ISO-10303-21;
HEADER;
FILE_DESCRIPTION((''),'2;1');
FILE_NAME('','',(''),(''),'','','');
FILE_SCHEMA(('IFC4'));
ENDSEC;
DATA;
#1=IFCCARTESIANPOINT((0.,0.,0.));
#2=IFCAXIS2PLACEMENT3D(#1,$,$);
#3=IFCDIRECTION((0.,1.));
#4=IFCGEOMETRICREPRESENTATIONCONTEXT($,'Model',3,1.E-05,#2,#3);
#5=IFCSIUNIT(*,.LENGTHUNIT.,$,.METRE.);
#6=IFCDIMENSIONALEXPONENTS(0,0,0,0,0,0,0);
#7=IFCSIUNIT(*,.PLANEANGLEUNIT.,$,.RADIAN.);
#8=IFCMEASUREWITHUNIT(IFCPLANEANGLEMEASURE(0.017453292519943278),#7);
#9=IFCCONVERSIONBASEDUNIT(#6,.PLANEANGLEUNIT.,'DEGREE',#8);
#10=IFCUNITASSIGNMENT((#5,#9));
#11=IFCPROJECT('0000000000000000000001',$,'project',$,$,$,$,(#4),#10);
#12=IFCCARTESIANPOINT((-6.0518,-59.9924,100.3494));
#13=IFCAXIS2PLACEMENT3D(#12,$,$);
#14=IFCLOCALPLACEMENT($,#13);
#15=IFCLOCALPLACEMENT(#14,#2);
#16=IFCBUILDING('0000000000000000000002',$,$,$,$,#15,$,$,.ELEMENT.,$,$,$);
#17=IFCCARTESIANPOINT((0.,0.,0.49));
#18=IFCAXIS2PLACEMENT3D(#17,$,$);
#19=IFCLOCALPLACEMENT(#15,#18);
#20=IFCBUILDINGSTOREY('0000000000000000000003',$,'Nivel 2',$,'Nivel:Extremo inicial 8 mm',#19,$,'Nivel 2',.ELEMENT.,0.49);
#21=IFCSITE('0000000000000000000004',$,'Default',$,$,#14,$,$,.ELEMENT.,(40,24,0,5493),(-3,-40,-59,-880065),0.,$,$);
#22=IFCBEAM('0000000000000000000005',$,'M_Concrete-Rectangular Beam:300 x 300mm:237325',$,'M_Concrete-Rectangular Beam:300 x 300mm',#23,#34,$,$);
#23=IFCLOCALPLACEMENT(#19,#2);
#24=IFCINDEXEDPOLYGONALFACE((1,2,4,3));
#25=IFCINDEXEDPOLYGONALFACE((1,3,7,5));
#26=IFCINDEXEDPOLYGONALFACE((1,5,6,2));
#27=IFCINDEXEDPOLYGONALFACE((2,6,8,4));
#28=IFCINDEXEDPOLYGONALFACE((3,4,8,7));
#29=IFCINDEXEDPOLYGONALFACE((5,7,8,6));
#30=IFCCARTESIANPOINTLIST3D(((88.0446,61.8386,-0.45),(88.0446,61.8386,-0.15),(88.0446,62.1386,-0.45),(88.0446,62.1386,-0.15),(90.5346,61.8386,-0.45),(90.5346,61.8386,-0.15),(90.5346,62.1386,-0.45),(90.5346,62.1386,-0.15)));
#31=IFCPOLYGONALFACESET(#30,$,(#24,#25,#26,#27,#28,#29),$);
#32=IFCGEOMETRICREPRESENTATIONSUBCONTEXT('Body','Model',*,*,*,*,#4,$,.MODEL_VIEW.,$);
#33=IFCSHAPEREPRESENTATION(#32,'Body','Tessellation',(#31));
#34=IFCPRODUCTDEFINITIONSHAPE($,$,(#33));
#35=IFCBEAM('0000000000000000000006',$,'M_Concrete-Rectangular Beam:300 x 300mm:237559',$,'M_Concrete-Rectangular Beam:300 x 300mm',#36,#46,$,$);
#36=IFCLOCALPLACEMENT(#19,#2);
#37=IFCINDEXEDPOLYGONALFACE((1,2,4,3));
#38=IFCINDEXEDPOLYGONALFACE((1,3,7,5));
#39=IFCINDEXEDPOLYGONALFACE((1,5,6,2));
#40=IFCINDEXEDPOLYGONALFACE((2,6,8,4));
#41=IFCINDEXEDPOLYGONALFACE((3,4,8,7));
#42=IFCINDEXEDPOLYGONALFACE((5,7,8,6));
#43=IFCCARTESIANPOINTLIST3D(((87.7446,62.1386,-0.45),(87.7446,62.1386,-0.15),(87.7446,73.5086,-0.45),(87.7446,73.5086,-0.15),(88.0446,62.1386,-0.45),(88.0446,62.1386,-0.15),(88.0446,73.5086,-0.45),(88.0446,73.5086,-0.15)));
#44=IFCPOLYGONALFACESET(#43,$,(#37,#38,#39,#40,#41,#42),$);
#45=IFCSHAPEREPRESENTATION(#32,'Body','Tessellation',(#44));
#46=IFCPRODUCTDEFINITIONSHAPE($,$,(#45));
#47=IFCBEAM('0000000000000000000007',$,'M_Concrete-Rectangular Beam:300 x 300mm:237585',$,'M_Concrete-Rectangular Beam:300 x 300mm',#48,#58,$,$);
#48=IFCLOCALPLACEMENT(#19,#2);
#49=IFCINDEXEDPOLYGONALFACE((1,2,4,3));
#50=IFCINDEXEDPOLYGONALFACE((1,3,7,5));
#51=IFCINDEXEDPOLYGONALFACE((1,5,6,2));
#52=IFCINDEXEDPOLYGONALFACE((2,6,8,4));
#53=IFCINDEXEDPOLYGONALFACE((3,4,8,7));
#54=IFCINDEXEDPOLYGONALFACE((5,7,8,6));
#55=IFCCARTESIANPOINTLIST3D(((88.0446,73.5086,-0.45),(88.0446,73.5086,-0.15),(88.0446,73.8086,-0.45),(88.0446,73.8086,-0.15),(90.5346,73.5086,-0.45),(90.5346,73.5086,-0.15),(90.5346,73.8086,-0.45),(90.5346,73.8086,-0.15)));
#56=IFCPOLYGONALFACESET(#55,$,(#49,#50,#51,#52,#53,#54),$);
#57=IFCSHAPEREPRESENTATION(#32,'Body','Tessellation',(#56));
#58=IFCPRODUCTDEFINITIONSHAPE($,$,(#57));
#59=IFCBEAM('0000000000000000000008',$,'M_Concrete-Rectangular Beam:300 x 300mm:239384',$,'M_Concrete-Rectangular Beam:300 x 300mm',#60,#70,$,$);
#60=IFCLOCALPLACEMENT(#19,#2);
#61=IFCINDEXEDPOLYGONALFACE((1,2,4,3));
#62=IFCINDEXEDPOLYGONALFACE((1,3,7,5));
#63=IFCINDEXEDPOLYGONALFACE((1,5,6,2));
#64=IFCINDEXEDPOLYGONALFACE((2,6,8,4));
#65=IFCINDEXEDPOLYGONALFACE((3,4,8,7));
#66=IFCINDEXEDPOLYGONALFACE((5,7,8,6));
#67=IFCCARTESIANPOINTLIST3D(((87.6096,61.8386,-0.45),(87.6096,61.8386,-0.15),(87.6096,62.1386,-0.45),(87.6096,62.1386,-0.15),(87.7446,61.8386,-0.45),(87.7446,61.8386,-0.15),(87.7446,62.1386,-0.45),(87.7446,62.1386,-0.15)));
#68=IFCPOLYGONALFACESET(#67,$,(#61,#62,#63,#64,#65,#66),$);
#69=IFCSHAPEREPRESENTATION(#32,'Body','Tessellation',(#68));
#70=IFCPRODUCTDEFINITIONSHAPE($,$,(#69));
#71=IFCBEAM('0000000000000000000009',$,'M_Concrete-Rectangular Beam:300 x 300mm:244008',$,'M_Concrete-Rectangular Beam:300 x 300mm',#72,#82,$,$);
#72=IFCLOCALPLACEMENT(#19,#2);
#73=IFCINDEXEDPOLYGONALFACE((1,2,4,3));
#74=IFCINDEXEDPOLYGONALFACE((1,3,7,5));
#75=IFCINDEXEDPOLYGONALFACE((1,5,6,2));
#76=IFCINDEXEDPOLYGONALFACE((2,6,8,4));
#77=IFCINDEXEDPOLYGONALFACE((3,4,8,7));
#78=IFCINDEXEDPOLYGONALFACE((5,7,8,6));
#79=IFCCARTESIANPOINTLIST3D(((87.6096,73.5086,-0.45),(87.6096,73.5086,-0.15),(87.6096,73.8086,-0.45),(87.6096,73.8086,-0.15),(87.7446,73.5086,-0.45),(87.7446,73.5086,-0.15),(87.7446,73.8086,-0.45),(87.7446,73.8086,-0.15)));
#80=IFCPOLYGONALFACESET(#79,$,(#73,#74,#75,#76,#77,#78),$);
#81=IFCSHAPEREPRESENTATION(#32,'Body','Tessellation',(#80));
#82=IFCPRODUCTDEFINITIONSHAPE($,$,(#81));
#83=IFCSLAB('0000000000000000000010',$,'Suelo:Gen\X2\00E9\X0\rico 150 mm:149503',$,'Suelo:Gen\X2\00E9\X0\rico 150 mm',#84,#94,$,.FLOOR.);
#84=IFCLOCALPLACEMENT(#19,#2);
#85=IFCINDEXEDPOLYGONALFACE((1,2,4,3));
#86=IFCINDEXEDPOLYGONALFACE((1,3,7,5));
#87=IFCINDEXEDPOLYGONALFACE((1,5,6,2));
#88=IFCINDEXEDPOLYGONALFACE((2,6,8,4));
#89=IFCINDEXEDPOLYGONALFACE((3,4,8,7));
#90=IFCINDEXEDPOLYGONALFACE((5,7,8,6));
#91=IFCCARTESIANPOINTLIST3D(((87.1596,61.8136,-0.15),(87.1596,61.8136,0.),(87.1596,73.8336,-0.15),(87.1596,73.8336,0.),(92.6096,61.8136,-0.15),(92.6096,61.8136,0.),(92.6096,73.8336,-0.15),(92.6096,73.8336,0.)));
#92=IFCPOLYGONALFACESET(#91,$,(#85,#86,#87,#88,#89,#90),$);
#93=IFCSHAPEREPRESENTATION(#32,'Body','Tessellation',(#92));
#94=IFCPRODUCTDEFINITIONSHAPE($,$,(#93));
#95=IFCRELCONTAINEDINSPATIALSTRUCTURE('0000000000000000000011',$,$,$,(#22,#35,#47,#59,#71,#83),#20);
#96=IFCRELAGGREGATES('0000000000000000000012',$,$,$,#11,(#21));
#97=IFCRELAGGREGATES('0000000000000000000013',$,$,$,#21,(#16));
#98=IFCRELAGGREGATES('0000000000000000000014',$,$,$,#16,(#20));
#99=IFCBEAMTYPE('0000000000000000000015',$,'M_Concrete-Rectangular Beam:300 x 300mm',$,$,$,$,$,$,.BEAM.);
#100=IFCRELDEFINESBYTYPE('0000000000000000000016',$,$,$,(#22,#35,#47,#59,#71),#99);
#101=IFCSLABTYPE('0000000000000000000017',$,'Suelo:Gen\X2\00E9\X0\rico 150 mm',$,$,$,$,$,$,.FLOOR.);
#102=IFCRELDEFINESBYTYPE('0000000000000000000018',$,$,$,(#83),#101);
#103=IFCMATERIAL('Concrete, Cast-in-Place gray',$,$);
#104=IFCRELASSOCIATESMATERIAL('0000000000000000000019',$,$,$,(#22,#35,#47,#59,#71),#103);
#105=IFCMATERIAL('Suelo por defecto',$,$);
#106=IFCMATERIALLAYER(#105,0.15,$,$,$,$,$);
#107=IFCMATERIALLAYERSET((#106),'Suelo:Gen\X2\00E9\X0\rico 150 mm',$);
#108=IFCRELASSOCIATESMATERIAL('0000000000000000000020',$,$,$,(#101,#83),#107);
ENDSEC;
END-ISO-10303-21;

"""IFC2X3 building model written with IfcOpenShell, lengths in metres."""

from ifc_helpers import new_model, entity, si_unit, converted_unit, direction, frame, frame_2d, origin, origin_2d_with_axis, place, context, subcontext, project, spatial, rectangle, extrude, material, layer, layer_set, layer_usage, type_object, element, save


model = new_model("IFC2X3")

# Units and contexts
model_context = context("Model", 3, precision=1e-05, world=origin(), true_north=direction((0.0, 1.0)))
body_context = subcontext(model_context, "Body", "Model", "MODEL_VIEW")
ifc_project = project(units=[si_unit("LENGTHUNIT", "METRE"), converted_unit("PLANEANGLEUNIT", "DEGREE", entity("IfcPlaneAngleMeasure", 0.017453292519943278), si_unit("PLANEANGLEUNIT", "RADIAN"), dimensions=[0, 0, 0, 0, 0, 0, 0])], contexts=[model_context])

# Site, building, storey
site_placement = place(None, frame((-6.0518, -59.9924, 100.3494)))
site = spatial("IfcSite", under=ifc_project, at=site_placement, Name="Default", CompositionType="ELEMENT", RefLatitude=(40, 24, 0, 5493), RefLongitude=(-3, -40, -59, -880065), RefElevation=0.0)
building_placement = place(site_placement, origin())
building = spatial("IfcBuilding", under=site, at=building_placement, CompositionType="ELEMENT")
storey_placement = place(building_placement, frame((0.0, 0.0, 0.49)))
storey = spatial("IfcBuildingStorey", under=building, at=storey_placement, Name="Nivel 2", ObjectType="Nivel:Extremo inicial 8 mm", LongName="Nivel 2", CompositionType="ELEMENT", Elevation=0.49)

# Shared definitions
ifc_material_1 = material(Name="Concrete, Cast-in-Place gray")

# Beams
beam_type = type_object("IfcBeamType", Name="M_Concrete-Rectangular Beam:300 x 300mm", PredefinedType="BEAM")
beam_1_placement = place(storey_placement, frame((87.8946, 61.9886, 0.0)))
element("IfcBeam", 1, at=beam_1_placement, inside=storey, type_object=beam_type, material=ifc_material_1, Name="M_Concrete-Rectangular Beam:300 x 300mm:237325", ObjectType="M_Concrete-Rectangular Beam:300 x 300mm", context=body_context, shape_type="SweptSolid", body=[
    extrude(rectangle(XDim=0.3, YDim=0.3, at=origin_2d_with_axis()), frame((0.15, 0.0, -0.3), z_axis=(1.0, 0.0, 0.0), x_axis=(0.0, 0.0, -1.0)), (0.0, 0.0, 1.0), 2.49),
])
beam_2_placement = place(storey_placement, frame((87.8946, 61.9886, 0.0), z_axis=(0.0, 0.0, 1.0), x_axis=(0.0, 1.0, 0.0)))
element("IfcBeam", 2, at=beam_2_placement, inside=storey, type_object=beam_type, material=ifc_material_1, Name="M_Concrete-Rectangular Beam:300 x 300mm:237559", ObjectType="M_Concrete-Rectangular Beam:300 x 300mm", context=body_context, shape_type="SweptSolid", body=[
    extrude(rectangle(XDim=0.3, YDim=0.3, at=origin_2d_with_axis()), frame((0.15, 0.0, -0.3), z_axis=(1.0, 0.0, 0.0), x_axis=(0.0, 0.0, -1.0)), (0.0, 0.0, 1.0), 11.37),
])
beam_3_placement = place(storey_placement, frame((87.8946, 73.6586, 0.0)))
element("IfcBeam", 3, at=beam_3_placement, inside=storey, type_object=beam_type, material=ifc_material_1, Name="M_Concrete-Rectangular Beam:300 x 300mm:237585", ObjectType="M_Concrete-Rectangular Beam:300 x 300mm", context=body_context, shape_type="SweptSolid", body=[
    extrude(rectangle(XDim=0.3, YDim=0.3, at=origin_2d_with_axis()), frame((0.15, 0.0, -0.3), z_axis=(1.0, 0.0, 0.0), x_axis=(0.0, 0.0, -1.0)), (0.0, 0.0, 1.0), 2.49),
])
beam_4_placement = place(storey_placement, frame((87.3096, 61.9886, 0.0)))
element("IfcBeam", 4, at=beam_4_placement, inside=storey, type_object=beam_type, material=ifc_material_1, Name="M_Concrete-Rectangular Beam:300 x 300mm:239384", ObjectType="M_Concrete-Rectangular Beam:300 x 300mm", context=body_context, shape_type="SweptSolid", body=[
    extrude(rectangle(XDim=0.3, YDim=0.3, at=origin_2d_with_axis()), frame((0.3, 0.0, -0.3), z_axis=(1.0, 0.0, 0.0), x_axis=(0.0, 0.0, -1.0)), (0.0, 0.0, 1.0), 0.135),
])
beam_5_placement = place(storey_placement, frame((87.3096, 73.6586, 0.0)))
element("IfcBeam", 5, at=beam_5_placement, inside=storey, type_object=beam_type, material=ifc_material_1, Name="M_Concrete-Rectangular Beam:300 x 300mm:244008", ObjectType="M_Concrete-Rectangular Beam:300 x 300mm", context=body_context, shape_type="SweptSolid", body=[
    extrude(rectangle(XDim=0.3, YDim=0.3, at=origin_2d_with_axis()), frame((0.3, 0.0, -0.3), z_axis=(1.0, 0.0, 0.0), x_axis=(0.0, 0.0, -1.0)), (0.0, 0.0, 1.0), 0.135),
])

# Slab
ifc_material_2 = material(Name="Suelo por defecto")
ifc_layer = layer(ifc_material_2, 0.15)
ifc_layer_set = layer_set([ifc_layer], Name="Suelo:Genérico 150 mm")
ifc_layer_usage = layer_usage(ifc_layer_set, "AXIS3", "POSITIVE", 0.0)
slab_type = type_object("IfcSlabType", Name="Suelo:Genérico 150 mm", PredefinedType="FLOOR", material=ifc_layer_set)
slab_placement = place(storey_placement, origin())
element("IfcSlab", 6, at=slab_placement, inside=storey, type_object=slab_type, material=ifc_layer_usage, Name="Suelo:Genérico 150 mm:149503", ObjectType="Suelo:Genérico 150 mm", PredefinedType="FLOOR", context=body_context, shape_type="SweptSolid", body=[
    extrude(rectangle(XDim=12.02, YDim=5.45, at=frame_2d((0.0, 0.0), x_axis=(1.0, 0.0))), frame((89.8846, 67.8236, 0.0), z_axis=(0.0, 0.0, -1.0), x_axis=(0.0, 1.0, 0.0)), (0.0, 0.0, 1.0), 0.15),
])

save(model, "model.ifc")
